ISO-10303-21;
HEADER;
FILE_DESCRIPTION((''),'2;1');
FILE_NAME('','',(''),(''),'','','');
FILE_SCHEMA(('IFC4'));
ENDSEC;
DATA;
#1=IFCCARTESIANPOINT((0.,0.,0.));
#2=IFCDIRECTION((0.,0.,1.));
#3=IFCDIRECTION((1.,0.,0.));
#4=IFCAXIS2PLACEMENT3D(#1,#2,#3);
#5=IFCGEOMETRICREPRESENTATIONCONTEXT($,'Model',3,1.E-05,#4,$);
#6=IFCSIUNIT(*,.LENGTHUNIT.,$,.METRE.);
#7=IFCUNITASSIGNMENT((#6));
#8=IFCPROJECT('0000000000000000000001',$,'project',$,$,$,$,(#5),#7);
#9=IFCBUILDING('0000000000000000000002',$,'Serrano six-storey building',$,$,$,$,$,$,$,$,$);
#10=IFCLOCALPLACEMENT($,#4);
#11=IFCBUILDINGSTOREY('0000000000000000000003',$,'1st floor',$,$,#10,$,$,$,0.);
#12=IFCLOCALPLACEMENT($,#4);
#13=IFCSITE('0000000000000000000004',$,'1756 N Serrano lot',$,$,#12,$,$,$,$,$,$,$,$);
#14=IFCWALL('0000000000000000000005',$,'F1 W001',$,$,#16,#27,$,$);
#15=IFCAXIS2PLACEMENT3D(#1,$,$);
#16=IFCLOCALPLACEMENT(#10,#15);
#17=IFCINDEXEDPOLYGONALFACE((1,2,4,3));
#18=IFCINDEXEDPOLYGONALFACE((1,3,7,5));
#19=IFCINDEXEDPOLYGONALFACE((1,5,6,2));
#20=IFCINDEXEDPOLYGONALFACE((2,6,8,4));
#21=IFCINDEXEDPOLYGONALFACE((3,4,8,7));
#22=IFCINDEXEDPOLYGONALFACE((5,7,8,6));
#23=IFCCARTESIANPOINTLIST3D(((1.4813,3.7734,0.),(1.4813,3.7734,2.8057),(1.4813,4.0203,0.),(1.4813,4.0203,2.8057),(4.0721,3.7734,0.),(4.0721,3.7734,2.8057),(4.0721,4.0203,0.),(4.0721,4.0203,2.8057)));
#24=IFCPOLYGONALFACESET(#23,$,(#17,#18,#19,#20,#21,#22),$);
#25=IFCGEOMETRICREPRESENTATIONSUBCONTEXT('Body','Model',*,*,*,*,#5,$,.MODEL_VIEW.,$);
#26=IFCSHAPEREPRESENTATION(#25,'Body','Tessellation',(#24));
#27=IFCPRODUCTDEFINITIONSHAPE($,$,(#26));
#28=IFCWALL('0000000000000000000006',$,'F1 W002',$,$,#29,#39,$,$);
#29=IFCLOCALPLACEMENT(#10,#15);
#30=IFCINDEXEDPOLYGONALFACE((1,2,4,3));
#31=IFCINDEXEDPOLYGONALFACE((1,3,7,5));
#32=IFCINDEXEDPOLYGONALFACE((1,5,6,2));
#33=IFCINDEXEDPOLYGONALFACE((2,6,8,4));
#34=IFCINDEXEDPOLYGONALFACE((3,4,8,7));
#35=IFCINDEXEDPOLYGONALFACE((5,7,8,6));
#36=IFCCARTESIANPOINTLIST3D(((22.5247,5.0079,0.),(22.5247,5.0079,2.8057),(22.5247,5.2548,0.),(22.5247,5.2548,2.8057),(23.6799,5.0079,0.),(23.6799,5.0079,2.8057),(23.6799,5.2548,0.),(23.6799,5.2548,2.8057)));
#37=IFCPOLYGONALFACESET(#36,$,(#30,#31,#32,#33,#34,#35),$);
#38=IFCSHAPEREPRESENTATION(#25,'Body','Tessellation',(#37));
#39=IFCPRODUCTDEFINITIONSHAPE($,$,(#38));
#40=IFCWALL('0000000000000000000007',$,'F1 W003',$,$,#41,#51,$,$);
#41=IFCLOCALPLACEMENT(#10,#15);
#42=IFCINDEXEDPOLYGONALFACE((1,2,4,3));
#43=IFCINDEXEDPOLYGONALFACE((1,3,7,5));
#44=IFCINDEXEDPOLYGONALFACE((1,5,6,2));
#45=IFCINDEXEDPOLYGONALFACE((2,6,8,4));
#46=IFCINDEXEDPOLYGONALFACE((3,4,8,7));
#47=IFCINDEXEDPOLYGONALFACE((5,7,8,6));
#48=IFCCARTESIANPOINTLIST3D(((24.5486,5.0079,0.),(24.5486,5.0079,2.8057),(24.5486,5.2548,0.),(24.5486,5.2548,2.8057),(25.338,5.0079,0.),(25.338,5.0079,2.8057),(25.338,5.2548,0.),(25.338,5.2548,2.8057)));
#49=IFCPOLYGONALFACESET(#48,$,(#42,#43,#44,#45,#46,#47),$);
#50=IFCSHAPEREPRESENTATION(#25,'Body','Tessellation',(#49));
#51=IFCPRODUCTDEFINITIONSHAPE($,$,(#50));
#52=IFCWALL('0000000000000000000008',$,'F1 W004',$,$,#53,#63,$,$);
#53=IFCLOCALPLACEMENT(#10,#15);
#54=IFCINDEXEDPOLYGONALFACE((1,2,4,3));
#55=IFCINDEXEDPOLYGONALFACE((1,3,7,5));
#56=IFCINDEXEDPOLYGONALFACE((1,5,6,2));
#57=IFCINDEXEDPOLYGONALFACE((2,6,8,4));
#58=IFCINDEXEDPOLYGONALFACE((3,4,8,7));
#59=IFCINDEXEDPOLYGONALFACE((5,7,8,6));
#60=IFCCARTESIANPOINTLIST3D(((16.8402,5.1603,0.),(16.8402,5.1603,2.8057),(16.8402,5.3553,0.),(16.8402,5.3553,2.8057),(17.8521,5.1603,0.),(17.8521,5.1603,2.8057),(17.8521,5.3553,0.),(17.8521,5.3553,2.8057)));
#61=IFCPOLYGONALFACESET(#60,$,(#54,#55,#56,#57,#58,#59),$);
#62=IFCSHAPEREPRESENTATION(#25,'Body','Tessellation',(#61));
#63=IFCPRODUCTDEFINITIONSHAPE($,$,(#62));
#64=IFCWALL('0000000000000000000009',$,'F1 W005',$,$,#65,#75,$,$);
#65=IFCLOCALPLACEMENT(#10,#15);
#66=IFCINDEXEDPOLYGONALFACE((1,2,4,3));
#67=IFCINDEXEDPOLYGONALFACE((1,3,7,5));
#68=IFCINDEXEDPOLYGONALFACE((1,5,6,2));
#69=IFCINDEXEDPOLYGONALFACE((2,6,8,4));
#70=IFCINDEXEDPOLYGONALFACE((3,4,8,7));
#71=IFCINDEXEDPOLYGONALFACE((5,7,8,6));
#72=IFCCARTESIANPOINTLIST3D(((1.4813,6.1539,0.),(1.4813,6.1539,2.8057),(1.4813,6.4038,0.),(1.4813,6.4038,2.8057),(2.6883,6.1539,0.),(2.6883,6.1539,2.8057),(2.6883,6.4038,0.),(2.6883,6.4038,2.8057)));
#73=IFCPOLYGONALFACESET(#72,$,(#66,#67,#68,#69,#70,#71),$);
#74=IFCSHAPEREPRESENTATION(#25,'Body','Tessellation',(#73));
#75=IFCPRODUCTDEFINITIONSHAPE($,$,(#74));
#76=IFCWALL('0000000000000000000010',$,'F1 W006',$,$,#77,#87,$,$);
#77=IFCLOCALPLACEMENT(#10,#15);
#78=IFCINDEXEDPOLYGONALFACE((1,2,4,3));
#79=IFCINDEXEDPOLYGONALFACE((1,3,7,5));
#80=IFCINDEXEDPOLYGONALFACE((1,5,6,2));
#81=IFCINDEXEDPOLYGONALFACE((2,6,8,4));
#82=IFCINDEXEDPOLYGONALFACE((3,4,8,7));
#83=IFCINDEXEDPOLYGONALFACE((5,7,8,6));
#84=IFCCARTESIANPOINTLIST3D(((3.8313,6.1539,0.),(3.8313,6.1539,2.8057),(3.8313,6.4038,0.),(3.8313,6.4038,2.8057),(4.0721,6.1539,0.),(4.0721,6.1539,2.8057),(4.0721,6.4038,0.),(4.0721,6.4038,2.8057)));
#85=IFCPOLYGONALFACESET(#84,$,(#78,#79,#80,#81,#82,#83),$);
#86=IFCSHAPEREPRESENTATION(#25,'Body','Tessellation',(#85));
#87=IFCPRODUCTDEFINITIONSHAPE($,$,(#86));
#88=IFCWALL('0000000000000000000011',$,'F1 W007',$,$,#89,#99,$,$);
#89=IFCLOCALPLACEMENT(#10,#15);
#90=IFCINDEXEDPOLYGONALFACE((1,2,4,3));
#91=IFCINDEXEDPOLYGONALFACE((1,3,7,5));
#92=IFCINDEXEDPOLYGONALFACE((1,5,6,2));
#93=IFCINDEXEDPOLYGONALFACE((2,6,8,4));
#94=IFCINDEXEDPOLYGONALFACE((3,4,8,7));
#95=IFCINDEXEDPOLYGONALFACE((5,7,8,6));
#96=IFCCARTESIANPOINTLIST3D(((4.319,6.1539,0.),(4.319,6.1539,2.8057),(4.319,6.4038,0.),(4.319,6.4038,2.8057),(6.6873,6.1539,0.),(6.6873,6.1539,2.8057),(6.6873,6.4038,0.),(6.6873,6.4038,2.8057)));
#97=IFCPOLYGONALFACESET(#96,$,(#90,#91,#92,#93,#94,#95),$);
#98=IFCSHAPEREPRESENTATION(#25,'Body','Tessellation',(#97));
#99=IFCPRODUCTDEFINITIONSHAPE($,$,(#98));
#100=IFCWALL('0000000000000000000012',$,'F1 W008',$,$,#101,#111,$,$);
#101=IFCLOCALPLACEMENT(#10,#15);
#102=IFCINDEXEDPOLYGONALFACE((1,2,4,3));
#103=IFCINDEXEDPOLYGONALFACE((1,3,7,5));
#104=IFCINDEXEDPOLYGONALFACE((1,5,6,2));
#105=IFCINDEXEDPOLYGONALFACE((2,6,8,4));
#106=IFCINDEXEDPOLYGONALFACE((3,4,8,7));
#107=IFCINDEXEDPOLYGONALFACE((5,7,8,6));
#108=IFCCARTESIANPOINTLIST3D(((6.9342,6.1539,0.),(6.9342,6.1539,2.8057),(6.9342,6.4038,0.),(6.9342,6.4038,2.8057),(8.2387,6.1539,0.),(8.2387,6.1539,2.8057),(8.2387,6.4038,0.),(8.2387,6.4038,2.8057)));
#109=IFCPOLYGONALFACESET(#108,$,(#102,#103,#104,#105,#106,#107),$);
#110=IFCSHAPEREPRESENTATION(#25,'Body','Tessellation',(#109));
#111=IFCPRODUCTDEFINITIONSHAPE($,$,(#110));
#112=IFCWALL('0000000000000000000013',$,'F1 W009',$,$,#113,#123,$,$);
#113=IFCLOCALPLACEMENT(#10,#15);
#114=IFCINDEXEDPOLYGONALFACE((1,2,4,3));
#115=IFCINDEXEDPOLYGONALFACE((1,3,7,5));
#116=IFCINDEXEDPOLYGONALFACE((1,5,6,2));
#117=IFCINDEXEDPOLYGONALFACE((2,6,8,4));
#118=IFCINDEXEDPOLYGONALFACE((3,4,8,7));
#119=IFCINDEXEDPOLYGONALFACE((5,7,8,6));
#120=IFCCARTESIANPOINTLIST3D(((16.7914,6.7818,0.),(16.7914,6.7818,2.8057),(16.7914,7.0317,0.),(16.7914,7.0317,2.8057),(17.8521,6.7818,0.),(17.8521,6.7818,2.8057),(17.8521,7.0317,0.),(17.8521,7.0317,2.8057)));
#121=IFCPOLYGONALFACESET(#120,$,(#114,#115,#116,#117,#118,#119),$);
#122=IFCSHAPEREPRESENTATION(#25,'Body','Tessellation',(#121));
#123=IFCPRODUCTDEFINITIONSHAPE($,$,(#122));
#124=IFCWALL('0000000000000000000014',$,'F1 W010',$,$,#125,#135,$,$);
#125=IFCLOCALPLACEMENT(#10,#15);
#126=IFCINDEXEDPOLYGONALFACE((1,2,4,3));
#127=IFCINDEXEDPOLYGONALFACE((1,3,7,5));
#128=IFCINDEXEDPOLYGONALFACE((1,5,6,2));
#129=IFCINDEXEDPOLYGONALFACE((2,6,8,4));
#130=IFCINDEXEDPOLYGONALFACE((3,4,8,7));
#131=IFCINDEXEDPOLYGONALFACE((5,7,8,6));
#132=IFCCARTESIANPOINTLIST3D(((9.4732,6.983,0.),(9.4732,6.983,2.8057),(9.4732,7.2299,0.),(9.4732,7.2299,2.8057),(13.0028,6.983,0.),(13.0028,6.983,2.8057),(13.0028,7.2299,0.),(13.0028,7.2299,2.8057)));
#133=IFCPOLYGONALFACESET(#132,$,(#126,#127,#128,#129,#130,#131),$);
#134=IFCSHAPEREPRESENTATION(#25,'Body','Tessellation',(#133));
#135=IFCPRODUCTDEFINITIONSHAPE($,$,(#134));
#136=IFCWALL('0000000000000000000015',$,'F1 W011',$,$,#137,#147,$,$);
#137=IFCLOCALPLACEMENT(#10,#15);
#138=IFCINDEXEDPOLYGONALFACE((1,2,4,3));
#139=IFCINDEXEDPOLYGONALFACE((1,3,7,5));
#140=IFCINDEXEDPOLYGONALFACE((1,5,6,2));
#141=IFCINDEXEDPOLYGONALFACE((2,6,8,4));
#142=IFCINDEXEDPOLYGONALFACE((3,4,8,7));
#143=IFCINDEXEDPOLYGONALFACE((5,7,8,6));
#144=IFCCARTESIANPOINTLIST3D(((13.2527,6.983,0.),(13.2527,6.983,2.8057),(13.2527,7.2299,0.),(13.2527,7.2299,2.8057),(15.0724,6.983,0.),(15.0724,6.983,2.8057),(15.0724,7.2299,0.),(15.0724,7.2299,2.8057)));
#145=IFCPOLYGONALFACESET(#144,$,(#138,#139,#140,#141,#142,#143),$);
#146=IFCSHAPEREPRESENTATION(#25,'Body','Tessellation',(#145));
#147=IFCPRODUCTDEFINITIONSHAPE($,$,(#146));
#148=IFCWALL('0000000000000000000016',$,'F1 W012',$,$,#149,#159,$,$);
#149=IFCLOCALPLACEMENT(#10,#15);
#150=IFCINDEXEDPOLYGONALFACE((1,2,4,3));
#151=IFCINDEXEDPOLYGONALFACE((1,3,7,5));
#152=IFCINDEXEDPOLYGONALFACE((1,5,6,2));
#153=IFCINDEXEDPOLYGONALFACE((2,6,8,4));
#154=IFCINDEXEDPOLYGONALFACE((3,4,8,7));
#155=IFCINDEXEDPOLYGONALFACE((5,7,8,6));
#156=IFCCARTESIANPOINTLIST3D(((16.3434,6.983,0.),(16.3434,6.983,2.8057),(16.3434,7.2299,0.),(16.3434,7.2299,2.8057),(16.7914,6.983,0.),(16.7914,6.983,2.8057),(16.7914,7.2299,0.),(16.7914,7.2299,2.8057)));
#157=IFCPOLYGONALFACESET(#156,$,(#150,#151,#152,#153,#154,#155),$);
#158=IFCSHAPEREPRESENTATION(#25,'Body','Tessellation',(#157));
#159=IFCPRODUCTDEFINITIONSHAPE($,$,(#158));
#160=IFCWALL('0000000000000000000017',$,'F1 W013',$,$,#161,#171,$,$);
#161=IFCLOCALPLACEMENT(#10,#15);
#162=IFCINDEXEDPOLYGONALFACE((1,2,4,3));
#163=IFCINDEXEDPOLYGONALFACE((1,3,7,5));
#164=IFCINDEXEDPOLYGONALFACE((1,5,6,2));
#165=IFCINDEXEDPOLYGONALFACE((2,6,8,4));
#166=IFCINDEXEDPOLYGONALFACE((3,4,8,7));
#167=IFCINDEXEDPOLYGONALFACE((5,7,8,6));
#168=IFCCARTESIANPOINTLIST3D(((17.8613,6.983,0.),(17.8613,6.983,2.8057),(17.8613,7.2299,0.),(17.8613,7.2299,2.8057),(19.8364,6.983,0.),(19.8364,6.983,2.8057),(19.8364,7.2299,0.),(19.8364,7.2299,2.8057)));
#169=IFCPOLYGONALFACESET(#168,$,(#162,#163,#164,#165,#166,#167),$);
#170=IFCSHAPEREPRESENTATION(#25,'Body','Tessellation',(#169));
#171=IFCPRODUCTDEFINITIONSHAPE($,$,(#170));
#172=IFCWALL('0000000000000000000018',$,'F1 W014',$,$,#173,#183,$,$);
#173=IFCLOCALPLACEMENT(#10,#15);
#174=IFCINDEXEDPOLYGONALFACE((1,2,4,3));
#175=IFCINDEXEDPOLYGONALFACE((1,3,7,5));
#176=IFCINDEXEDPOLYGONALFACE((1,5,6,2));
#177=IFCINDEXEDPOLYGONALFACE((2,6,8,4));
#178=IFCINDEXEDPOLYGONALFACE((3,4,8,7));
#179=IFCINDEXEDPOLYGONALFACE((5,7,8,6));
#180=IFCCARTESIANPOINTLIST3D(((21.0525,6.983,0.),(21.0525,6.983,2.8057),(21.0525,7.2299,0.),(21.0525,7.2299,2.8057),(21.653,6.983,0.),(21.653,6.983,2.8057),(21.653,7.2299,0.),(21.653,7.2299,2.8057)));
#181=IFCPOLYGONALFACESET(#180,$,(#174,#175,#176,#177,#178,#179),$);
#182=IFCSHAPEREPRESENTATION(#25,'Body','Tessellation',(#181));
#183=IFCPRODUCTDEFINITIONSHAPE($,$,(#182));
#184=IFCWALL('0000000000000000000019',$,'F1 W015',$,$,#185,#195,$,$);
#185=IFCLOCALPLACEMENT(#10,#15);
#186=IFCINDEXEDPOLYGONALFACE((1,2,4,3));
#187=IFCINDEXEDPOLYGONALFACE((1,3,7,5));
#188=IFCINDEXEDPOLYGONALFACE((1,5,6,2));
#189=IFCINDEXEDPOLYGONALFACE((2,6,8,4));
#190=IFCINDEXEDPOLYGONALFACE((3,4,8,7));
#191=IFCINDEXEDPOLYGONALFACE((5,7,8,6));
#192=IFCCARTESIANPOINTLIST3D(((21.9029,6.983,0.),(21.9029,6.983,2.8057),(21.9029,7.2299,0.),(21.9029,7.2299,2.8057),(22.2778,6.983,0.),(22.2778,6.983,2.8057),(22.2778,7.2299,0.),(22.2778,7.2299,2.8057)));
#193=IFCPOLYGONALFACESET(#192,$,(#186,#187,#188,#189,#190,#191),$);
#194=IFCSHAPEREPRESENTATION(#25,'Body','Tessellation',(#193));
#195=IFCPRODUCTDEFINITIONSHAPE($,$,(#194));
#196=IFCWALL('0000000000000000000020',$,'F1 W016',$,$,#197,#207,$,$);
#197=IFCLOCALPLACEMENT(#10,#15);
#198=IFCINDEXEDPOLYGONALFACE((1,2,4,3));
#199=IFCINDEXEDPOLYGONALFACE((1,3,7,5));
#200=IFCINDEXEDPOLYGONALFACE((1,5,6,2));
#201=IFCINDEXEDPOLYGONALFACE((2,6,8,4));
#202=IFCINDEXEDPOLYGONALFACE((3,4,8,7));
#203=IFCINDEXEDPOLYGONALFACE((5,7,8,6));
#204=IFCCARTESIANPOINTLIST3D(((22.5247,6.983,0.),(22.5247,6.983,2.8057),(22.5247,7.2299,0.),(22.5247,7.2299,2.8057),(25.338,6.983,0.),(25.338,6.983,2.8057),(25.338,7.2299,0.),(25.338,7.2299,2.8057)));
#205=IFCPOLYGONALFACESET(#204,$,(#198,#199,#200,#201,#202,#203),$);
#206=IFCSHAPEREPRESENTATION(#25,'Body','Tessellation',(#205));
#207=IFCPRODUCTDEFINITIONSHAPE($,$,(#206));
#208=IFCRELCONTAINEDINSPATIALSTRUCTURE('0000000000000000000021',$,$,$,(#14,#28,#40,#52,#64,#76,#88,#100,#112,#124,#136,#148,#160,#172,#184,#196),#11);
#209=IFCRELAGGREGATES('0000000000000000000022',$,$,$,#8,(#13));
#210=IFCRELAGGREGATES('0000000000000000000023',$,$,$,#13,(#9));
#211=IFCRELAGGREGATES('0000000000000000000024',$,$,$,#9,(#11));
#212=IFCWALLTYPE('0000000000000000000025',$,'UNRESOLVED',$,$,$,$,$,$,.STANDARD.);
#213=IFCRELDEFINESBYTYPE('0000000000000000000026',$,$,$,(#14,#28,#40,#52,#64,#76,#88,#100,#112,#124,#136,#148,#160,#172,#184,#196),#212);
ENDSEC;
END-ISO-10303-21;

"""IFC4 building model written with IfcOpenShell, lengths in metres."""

from ifc_helpers import new_model, si_unit, origin, origin_with_axes, place, context, subcontext, project, spatial, polyline, outline, extrude, type_object, element, save


model = new_model("IFC4")

# Units and contexts
model_context = context("Model", 3, precision=1e-05, world=origin_with_axes())
body_context = subcontext(model_context, "Body", "Model", "MODEL_VIEW")
ifc_project = project(units=[si_unit("LENGTHUNIT", "METRE")], contexts=[model_context])

# Site, building, storey
site_placement = place(None, origin_with_axes())
site = spatial("IfcSite", under=ifc_project, at=site_placement, Name="1756 N Serrano lot")
building = spatial("IfcBuilding", under=site, Name="Serrano six-storey building")
storey_placement = place(None, origin_with_axes())
storey = spatial("IfcBuildingStorey", under=building, at=storey_placement, Name="1st floor", Elevation=0.0)

# Walls
wall_type = type_object("IfcWallType", Name="UNRESOLVED", PredefinedType="STANDARD")
wall_1_placement = place(storey_placement, origin_with_axes())
element("IfcWall", 1, at=wall_1_placement, inside=storey, type_object=wall_type, Name="F1 W001", context=body_context, shape_type="SweptSolid", body=[
    extrude(outline(polyline([(4.0721, 4.0203), (4.0721, 3.7734), (1.4813, 3.7734), (1.4813, 4.0203), (4.0721, 4.0203)])), origin(), (0.0, 0.0, 1.0), 2.8057),
])
wall_2_placement = place(storey_placement, origin_with_axes())
element("IfcWall", 2, at=wall_2_placement, inside=storey, type_object=wall_type, Name="F1 W002", context=body_context, shape_type="SweptSolid", body=[
    extrude(outline(polyline([(23.6799, 5.2548), (23.6799, 5.0079), (22.5247, 5.0079), (22.5247, 5.2548), (23.6799, 5.2548)])), origin(), (0.0, 0.0, 1.0), 2.8057),
])
wall_3_placement = place(storey_placement, origin_with_axes())
element("IfcWall", 3, at=wall_3_placement, inside=storey, type_object=wall_type, Name="F1 W003", context=body_context, shape_type="SweptSolid", body=[
    extrude(outline(polyline([(25.338, 5.2548), (25.338, 5.0079), (24.5486, 5.0079), (24.5486, 5.2548), (25.338, 5.2548)])), origin(), (0.0, 0.0, 1.0), 2.8057),
])
wall_4_placement = place(storey_placement, origin_with_axes())
element("IfcWall", 4, at=wall_4_placement, inside=storey, type_object=wall_type, Name="F1 W004", context=body_context, shape_type="SweptSolid", body=[
    extrude(outline(polyline([(17.8521, 5.3553), (17.8521, 5.1603), (16.8402, 5.1603), (16.8402, 5.3553), (17.8521, 5.3553)])), origin(), (0.0, 0.0, 1.0), 2.8057),
])
wall_5_placement = place(storey_placement, origin_with_axes())
element("IfcWall", 5, at=wall_5_placement, inside=storey, type_object=wall_type, Name="F1 W005", context=body_context, shape_type="SweptSolid", body=[
    extrude(outline(polyline([(2.6883, 6.4038), (2.6883, 6.1539), (1.4813, 6.1539), (1.4813, 6.4038), (2.6883, 6.4038)])), origin(), (0.0, 0.0, 1.0), 2.8057),
])
wall_6_placement = place(storey_placement, origin_with_axes())
element("IfcWall", 6, at=wall_6_placement, inside=storey, type_object=wall_type, Name="F1 W006", context=body_context, shape_type="SweptSolid", body=[
    extrude(outline(polyline([(4.0721, 6.4038), (4.0721, 6.1539), (3.8313, 6.1539), (3.8313, 6.4038), (4.0721, 6.4038)])), origin(), (0.0, 0.0, 1.0), 2.8057),
])
wall_7_placement = place(storey_placement, origin_with_axes())
element("IfcWall", 7, at=wall_7_placement, inside=storey, type_object=wall_type, Name="F1 W007", context=body_context, shape_type="SweptSolid", body=[
    extrude(outline(polyline([(6.6873, 6.4038), (6.6873, 6.1539), (4.319, 6.1539), (4.319, 6.4038), (6.6873, 6.4038)])), origin(), (0.0, 0.0, 1.0), 2.8057),
])
wall_8_placement = place(storey_placement, origin_with_axes())
element("IfcWall", 8, at=wall_8_placement, inside=storey, type_object=wall_type, Name="F1 W008", context=body_context, shape_type="SweptSolid", body=[
    extrude(outline(polyline([(8.2387, 6.4038), (8.2387, 6.1539), (6.9342, 6.1539), (6.9342, 6.4038), (8.2387, 6.4038)])), origin(), (0.0, 0.0, 1.0), 2.8057),
])
wall_9_placement = place(storey_placement, origin_with_axes())
element("IfcWall", 9, at=wall_9_placement, inside=storey, type_object=wall_type, Name="F1 W009", context=body_context, shape_type="SweptSolid", body=[
    extrude(outline(polyline([(17.8521, 7.0317), (17.8521, 6.7818), (16.7914, 6.7818), (16.7914, 7.0317), (17.8521, 7.0317)])), origin(), (0.0, 0.0, 1.0), 2.8057),
])
wall_10_placement = place(storey_placement, origin_with_axes())
element("IfcWall", 10, at=wall_10_placement, inside=storey, type_object=wall_type, Name="F1 W010", context=body_context, shape_type="SweptSolid", body=[
    extrude(outline(polyline([(13.0028, 7.2299), (13.0028, 6.983), (9.4732, 6.983), (9.4732, 7.2299), (13.0028, 7.2299)])), origin(), (0.0, 0.0, 1.0), 2.8057),
])
wall_11_placement = place(storey_placement, origin_with_axes())
element("IfcWall", 11, at=wall_11_placement, inside=storey, type_object=wall_type, Name="F1 W011", context=body_context, shape_type="SweptSolid", body=[
    extrude(outline(polyline([(15.0724, 7.2299), (15.0724, 6.983), (13.2527, 6.983), (13.2527, 7.2299), (15.0724, 7.2299)])), origin(), (0.0, 0.0, 1.0), 2.8057),
])
wall_12_placement = place(storey_placement, origin_with_axes())
element("IfcWall", 12, at=wall_12_placement, inside=storey, type_object=wall_type, Name="F1 W012", context=body_context, shape_type="SweptSolid", body=[
    extrude(outline(polyline([(16.7914, 7.2299), (16.7914, 6.983), (16.3434, 6.983), (16.3434, 7.2299), (16.7914, 7.2299)])), origin(), (0.0, 0.0, 1.0), 2.8057),
])
wall_13_placement = place(storey_placement, origin_with_axes())
element("IfcWall", 13, at=wall_13_placement, inside=storey, type_object=wall_type, Name="F1 W013", context=body_context, shape_type="SweptSolid", body=[
    extrude(outline(polyline([(19.8364, 7.2299), (19.8364, 6.983), (17.8613, 6.983), (17.8613, 7.2299), (19.8364, 7.2299)])), origin(), (0.0, 0.0, 1.0), 2.8057),
])
wall_14_placement = place(storey_placement, origin_with_axes())
element("IfcWall", 14, at=wall_14_placement, inside=storey, type_object=wall_type, Name="F1 W014", context=body_context, shape_type="SweptSolid", body=[
    extrude(outline(polyline([(21.653, 7.2299), (21.653, 6.983), (21.0525, 6.983), (21.0525, 7.2299), (21.653, 7.2299)])), origin(), (0.0, 0.0, 1.0), 2.8057),
])
wall_15_placement = place(storey_placement, origin_with_axes())
element("IfcWall", 15, at=wall_15_placement, inside=storey, type_object=wall_type, Name="F1 W015", context=body_context, shape_type="SweptSolid", body=[
    extrude(outline(polyline([(22.2778, 7.2299), (22.2778, 6.983), (21.9029, 6.983), (21.9029, 7.2299), (22.2778, 7.2299)])), origin(), (0.0, 0.0, 1.0), 2.8057),
])
wall_16_placement = place(storey_placement, origin_with_axes())
element("IfcWall", 16, at=wall_16_placement, inside=storey, type_object=wall_type, Name="F1 W016", context=body_context, shape_type="SweptSolid", body=[
    extrude(outline(polyline([(25.338, 7.2299), (25.338, 6.983), (22.5247, 6.983), (22.5247, 7.2299), (25.338, 7.2299)])), origin(), (0.0, 0.0, 1.0), 2.8057),
])

save(model, "model.ifc")
